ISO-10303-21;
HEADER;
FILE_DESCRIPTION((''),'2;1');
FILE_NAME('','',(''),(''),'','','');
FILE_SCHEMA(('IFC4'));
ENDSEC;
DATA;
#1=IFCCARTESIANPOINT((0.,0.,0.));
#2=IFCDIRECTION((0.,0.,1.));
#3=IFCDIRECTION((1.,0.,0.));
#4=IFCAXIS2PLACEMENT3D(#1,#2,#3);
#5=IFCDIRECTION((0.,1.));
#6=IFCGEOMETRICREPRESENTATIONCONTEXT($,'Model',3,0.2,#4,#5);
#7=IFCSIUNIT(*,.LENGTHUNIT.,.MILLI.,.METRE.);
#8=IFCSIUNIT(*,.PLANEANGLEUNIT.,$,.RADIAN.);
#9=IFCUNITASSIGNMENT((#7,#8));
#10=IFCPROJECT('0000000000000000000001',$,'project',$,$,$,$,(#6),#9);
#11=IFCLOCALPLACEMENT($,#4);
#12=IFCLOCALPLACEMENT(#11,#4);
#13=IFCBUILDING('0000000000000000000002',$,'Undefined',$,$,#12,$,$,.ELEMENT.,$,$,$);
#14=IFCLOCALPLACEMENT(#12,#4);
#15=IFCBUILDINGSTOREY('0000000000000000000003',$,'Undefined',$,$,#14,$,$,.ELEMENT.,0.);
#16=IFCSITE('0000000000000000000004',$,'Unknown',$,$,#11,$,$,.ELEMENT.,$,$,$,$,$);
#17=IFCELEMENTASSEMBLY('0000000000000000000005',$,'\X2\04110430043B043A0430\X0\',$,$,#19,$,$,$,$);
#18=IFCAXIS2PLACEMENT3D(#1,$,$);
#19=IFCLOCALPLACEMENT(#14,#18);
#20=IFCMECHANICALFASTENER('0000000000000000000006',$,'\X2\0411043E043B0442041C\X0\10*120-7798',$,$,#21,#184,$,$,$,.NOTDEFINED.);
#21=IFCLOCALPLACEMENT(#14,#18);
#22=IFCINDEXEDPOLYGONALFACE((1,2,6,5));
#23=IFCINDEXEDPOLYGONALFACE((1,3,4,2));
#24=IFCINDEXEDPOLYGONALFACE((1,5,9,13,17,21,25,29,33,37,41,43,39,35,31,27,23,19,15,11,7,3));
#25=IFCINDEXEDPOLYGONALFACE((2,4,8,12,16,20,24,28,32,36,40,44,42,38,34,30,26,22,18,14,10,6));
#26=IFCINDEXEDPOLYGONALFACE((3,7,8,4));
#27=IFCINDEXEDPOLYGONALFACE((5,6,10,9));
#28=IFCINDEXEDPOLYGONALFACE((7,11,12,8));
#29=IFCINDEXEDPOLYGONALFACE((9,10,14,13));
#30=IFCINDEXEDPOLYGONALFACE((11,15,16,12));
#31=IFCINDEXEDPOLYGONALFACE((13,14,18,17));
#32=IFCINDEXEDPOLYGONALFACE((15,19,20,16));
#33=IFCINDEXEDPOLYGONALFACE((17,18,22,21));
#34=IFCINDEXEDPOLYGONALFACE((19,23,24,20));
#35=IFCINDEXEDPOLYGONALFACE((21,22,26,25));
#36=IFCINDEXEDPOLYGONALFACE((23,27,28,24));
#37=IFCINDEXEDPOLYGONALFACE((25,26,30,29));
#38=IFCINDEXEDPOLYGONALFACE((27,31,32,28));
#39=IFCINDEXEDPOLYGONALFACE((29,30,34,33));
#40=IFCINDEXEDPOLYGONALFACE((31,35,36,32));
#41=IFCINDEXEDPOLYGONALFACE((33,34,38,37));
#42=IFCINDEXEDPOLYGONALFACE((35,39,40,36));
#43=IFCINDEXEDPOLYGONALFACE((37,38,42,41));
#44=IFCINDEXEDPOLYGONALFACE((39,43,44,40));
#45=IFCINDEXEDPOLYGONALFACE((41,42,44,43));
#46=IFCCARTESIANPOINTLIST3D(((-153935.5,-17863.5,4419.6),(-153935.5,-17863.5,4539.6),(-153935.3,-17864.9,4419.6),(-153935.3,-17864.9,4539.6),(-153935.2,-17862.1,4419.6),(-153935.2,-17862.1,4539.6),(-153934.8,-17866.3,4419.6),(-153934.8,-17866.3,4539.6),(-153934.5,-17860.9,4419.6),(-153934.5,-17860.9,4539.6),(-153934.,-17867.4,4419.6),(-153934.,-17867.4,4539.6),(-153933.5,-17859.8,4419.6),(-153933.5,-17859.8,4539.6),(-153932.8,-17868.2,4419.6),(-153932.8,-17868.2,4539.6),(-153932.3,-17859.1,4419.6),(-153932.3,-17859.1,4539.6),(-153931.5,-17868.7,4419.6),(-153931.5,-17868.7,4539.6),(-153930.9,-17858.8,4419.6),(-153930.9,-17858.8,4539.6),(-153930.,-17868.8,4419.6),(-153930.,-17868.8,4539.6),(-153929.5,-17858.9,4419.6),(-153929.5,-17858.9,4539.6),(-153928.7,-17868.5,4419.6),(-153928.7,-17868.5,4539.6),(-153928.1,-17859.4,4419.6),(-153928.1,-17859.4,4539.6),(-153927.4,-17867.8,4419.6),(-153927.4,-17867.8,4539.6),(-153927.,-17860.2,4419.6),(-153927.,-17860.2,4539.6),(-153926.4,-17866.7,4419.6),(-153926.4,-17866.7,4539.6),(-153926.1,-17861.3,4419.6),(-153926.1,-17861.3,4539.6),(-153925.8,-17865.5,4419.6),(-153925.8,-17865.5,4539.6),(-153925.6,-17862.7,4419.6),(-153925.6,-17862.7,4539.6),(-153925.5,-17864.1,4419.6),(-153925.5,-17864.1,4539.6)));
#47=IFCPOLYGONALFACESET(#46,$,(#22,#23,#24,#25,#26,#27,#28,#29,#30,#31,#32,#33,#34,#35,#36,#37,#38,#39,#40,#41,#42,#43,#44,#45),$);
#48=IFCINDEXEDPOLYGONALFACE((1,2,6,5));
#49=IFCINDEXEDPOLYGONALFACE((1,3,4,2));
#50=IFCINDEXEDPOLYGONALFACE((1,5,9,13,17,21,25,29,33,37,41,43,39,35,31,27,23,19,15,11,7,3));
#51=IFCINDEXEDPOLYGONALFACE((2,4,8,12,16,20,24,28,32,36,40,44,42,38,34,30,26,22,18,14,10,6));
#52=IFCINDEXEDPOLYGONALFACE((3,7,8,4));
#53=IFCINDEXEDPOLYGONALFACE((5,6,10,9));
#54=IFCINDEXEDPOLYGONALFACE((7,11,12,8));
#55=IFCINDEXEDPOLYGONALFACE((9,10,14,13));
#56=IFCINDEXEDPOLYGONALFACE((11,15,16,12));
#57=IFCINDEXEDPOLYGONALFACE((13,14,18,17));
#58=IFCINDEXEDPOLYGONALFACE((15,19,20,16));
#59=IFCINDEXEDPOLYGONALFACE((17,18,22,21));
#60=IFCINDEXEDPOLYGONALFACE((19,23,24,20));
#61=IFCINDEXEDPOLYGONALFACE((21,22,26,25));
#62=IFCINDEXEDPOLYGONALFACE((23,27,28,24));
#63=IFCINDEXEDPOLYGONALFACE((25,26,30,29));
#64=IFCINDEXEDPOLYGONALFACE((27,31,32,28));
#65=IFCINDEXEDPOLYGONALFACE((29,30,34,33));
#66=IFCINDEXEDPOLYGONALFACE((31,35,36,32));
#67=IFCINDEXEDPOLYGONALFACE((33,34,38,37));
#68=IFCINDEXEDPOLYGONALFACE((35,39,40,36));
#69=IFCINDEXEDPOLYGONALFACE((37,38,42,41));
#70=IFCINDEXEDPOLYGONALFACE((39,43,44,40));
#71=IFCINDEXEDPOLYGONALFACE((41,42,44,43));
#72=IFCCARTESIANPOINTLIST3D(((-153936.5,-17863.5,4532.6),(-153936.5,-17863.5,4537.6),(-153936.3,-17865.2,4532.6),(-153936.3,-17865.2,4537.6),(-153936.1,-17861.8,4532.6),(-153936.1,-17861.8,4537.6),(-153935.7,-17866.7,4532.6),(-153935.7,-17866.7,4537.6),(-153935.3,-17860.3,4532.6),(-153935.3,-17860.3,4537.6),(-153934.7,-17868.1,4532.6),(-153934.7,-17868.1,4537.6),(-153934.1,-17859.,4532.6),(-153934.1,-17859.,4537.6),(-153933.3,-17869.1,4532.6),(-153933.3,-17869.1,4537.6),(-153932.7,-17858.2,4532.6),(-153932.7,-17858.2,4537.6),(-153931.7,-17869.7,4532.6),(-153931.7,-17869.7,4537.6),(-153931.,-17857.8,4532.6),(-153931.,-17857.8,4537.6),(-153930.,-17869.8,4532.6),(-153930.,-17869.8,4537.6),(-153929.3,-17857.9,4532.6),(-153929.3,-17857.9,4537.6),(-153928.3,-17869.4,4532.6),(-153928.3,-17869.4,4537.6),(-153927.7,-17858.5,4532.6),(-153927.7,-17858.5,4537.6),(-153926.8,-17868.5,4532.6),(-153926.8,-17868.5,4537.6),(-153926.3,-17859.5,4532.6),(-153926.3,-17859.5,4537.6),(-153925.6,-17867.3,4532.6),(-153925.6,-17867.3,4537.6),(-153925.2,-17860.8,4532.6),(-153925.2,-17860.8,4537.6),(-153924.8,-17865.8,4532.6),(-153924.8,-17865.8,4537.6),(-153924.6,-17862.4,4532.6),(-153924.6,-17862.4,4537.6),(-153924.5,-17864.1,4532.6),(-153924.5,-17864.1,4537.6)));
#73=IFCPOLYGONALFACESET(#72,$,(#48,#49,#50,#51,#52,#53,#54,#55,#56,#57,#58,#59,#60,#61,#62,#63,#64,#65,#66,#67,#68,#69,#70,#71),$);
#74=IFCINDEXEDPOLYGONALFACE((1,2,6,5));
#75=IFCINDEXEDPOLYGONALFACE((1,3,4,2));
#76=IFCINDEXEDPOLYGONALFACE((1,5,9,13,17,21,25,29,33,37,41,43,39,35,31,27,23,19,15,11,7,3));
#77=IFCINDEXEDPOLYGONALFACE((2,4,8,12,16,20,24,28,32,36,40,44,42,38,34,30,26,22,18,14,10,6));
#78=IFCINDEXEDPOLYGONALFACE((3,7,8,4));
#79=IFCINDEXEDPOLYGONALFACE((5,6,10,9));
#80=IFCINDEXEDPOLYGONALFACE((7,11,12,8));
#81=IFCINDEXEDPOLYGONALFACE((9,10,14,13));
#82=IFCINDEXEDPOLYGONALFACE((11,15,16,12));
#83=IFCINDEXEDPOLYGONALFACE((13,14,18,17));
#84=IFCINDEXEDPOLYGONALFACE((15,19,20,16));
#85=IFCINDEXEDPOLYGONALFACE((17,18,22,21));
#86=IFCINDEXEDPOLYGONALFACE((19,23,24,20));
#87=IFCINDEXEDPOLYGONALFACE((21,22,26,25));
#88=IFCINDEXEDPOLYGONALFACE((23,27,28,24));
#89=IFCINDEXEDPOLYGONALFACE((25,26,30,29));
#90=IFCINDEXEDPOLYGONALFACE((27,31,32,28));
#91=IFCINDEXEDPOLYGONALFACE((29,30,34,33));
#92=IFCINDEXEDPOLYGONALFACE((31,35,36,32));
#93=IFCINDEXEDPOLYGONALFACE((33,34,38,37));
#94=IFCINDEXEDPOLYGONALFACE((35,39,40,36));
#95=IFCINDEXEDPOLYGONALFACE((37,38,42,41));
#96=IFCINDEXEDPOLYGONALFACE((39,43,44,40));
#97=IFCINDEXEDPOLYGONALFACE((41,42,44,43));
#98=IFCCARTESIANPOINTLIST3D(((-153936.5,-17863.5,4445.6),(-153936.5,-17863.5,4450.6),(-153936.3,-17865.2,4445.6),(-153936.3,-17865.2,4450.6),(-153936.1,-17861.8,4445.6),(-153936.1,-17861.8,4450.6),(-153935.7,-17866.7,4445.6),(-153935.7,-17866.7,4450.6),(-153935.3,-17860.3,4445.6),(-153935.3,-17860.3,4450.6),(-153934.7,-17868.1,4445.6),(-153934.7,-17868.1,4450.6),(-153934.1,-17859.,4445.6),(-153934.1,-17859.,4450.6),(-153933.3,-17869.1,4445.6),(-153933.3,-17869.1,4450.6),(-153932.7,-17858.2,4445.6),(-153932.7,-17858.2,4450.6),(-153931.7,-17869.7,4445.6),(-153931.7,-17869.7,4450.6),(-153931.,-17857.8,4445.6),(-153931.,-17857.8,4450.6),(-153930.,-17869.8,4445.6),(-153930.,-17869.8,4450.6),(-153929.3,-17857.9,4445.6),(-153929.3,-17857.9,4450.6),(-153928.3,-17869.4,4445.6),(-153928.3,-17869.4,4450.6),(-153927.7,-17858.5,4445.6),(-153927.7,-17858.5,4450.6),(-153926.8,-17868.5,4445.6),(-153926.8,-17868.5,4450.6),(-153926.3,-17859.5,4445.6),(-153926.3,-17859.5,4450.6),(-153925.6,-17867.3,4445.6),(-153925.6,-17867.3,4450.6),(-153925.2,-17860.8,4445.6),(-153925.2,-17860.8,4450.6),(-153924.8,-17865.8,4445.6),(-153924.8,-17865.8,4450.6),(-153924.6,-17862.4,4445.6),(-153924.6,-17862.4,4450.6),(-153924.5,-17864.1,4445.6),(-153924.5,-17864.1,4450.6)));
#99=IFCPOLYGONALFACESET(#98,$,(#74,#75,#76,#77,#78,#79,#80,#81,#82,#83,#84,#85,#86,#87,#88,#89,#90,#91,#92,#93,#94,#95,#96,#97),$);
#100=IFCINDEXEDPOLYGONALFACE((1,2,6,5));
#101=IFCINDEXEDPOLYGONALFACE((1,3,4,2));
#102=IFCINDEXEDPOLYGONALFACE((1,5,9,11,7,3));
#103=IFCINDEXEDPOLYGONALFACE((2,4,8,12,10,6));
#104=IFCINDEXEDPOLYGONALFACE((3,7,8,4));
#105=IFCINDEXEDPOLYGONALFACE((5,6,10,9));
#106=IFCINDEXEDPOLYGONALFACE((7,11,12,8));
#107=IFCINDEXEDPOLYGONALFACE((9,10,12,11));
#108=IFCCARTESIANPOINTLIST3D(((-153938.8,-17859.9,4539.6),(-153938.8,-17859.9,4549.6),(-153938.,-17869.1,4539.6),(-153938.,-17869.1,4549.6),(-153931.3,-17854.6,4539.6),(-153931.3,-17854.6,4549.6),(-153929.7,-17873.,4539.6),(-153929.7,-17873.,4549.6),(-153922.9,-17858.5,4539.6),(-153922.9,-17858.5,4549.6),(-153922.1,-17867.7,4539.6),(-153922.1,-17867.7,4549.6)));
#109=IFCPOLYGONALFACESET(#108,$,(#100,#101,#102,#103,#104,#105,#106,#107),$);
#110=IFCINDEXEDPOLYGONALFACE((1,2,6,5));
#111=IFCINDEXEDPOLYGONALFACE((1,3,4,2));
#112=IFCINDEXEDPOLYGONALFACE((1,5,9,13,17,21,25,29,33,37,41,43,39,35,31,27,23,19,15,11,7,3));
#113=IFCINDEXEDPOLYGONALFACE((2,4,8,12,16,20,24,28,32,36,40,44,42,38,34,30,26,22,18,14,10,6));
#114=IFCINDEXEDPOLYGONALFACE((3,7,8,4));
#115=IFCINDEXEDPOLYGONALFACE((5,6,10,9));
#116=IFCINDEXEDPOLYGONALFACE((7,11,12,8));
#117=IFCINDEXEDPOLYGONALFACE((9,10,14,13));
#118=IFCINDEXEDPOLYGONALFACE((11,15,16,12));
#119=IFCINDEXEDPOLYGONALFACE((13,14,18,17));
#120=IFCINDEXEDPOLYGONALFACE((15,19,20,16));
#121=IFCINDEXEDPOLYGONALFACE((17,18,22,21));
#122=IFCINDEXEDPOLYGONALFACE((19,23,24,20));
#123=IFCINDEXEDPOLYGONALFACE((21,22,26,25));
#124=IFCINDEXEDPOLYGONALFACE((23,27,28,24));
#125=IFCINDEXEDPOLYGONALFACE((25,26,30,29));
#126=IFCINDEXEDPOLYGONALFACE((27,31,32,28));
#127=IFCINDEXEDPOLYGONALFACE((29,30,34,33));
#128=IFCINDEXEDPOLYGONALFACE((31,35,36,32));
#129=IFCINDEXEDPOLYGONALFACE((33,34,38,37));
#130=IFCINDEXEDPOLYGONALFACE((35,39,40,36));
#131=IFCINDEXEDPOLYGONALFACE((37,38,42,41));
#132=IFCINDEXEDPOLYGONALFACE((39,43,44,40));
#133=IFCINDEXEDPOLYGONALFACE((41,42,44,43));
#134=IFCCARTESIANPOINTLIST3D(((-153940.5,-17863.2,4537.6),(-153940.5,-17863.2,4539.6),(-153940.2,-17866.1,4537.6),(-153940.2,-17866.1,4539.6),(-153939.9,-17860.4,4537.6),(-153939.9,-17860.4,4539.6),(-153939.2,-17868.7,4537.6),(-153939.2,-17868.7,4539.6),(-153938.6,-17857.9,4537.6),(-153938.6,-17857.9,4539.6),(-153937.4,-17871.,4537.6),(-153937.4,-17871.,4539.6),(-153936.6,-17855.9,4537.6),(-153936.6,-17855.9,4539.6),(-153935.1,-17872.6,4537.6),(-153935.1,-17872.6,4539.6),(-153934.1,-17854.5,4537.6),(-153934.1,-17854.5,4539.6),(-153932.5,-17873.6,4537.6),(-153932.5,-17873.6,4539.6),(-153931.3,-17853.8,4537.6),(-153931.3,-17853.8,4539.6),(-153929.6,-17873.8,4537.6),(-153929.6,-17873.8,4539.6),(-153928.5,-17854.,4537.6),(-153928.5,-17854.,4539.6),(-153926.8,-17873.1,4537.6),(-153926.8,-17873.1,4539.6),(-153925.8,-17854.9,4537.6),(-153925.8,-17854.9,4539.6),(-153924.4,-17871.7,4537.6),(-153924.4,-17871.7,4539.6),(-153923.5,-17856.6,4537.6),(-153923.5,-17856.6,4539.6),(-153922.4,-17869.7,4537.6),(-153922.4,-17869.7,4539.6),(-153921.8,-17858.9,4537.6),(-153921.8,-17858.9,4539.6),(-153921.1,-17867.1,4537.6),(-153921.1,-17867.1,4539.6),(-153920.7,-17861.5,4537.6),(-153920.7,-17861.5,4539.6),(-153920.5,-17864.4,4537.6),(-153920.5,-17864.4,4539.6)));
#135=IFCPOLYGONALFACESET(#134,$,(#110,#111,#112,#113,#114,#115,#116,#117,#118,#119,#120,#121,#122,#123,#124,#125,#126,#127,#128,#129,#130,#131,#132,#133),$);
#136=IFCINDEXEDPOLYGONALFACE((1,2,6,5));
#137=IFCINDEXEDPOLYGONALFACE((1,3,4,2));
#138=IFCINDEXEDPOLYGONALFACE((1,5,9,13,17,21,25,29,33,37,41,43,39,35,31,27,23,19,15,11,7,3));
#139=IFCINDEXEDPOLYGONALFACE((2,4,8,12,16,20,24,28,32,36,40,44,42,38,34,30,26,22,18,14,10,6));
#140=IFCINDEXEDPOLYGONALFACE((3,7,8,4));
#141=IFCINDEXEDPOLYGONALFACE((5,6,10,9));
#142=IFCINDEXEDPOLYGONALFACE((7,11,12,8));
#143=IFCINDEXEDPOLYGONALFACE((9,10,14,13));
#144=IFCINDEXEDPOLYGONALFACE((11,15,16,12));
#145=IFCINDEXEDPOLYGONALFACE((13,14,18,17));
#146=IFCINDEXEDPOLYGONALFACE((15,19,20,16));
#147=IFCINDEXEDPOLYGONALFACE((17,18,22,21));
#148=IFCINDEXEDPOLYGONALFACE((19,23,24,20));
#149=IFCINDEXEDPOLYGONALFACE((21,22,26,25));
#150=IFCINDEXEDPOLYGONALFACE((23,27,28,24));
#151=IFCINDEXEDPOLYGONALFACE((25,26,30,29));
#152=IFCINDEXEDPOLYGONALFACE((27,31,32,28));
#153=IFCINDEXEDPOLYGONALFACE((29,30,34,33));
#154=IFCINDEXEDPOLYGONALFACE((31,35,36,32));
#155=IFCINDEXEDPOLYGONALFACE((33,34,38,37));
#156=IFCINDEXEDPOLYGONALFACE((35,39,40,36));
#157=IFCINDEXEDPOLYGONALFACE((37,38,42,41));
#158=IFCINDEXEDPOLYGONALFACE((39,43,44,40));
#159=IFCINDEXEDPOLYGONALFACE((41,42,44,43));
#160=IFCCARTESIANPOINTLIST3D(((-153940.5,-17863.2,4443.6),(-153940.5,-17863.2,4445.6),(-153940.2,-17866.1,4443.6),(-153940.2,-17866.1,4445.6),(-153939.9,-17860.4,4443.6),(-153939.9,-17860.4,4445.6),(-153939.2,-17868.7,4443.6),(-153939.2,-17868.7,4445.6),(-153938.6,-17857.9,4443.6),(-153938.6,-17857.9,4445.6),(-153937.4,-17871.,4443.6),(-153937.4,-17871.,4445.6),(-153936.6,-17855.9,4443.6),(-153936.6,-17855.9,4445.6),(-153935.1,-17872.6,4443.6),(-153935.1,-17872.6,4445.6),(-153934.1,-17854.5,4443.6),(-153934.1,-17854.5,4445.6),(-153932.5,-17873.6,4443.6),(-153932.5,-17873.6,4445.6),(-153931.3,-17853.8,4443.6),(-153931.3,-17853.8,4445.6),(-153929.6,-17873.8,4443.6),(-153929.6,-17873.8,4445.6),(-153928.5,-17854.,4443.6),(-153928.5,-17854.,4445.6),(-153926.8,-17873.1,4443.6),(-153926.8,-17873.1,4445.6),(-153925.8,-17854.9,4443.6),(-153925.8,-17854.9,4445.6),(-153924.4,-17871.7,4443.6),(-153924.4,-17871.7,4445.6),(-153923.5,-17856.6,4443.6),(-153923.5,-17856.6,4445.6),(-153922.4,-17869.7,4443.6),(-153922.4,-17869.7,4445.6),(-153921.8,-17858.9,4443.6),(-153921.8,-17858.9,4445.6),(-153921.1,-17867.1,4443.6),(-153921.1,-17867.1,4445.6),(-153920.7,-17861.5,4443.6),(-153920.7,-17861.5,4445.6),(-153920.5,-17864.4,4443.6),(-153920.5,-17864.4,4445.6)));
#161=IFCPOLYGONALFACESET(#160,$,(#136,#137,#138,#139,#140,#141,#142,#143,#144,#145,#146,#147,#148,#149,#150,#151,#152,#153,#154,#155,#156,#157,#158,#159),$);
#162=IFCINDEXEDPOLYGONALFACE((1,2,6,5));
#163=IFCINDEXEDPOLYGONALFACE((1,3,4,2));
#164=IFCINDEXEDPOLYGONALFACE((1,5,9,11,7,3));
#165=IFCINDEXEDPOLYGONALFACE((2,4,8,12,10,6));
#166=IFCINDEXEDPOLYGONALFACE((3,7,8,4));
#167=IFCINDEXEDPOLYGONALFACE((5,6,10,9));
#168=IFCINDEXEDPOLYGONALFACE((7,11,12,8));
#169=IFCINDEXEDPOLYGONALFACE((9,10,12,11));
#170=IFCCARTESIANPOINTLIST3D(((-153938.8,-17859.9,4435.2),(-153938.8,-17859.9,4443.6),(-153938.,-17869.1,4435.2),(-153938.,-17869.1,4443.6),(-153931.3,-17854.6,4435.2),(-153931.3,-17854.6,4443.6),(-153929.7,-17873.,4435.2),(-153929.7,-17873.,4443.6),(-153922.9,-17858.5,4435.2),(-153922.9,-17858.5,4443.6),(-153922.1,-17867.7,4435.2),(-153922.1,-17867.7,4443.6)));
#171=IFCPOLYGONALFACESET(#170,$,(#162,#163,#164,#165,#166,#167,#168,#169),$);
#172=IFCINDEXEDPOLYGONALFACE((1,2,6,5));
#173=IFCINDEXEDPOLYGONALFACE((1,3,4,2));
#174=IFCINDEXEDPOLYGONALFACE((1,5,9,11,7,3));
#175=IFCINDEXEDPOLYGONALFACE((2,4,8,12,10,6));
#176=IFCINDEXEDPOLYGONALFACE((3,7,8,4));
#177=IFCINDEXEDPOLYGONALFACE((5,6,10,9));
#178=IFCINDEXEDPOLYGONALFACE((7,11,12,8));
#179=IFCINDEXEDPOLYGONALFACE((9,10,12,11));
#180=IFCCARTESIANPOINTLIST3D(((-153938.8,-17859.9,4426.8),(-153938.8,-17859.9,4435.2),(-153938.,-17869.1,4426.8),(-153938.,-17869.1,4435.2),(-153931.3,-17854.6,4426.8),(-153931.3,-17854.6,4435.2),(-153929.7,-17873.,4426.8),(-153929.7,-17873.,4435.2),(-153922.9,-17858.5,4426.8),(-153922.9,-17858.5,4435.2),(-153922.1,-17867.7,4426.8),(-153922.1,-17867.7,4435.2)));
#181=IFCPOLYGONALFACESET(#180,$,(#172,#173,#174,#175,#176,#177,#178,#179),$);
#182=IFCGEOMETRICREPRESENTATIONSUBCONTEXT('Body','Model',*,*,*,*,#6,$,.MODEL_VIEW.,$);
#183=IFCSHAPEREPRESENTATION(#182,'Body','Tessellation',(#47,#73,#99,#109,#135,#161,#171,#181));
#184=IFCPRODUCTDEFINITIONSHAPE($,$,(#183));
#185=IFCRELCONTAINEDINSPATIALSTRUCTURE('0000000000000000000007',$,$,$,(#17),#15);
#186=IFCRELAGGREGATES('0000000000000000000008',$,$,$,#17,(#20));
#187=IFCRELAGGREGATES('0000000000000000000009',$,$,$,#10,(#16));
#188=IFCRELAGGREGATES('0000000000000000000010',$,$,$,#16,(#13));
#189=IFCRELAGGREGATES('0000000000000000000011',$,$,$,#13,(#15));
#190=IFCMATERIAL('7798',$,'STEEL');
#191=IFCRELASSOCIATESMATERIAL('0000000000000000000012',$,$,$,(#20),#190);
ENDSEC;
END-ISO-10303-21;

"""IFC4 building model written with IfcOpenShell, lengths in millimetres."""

from ifc_helpers import new_model, si_unit, direction, frame, origin_with_axes, place, context, subcontext, project, spatial, line, arc, indexed_curve, outline, extrude, source, transform, mapped, material, element, aggregate, save


model = new_model("IFC4")

# Units and contexts
model_context = context("Model", 3, precision=0.2, world=origin_with_axes(), true_north=direction((0.0, 1.0)))
body_context = subcontext(model_context, "Body", "Model", "MODEL_VIEW")
ifc_project = project(units=[si_unit("LENGTHUNIT", "METRE", prefix="MILLI"), si_unit("PLANEANGLEUNIT", "RADIAN")], contexts=[model_context])

# Site, building, storey
site_placement = place(None, origin_with_axes())
site = spatial("IfcSite", under=ifc_project, at=site_placement, Name="Unknown", CompositionType="ELEMENT")
building_placement = place(site_placement, origin_with_axes())
building = spatial("IfcBuilding", under=site, at=building_placement, Name="Undefined", CompositionType="ELEMENT")
storey_placement = place(building_placement, origin_with_axes())
storey = spatial("IfcBuildingStorey", under=building, at=storey_placement, Name="Undefined", CompositionType="ELEMENT", Elevation=0.0)

# Element assembly
assembly_1_placement = place(storey_placement, frame((-154078.4, -17876.6, 4581.6), z_axis=(0.996285, 0.086114, 0.0), x_axis=(0.0, 0.0, -1.0)))
assembly_1 = element("IfcElementAssembly", 1, at=assembly_1_placement, inside=storey, Name="Балка")

# Shared definitions
ifc_material_1 = material(Name="7798", Category="STEEL")

# Mechanical fastener
shared_shape_1 = source(origin_with_axes(), body_context, "Body", "SweptSolid", [
    extrude(outline(indexed_curve([(5.0, 0.0), (0.0, 5.0), (-5.0, 0.0), (0.0, -5.0)], segments=[arc(1, 2, 3), arc(3, 4, 1)])), frame((0.0, 0.0, 7.0), z_axis=(0.0, 0.0, -1.0), x_axis=(0.0, 1.0, 0.0)), (0.0, 0.0, 1.0), 120.0),
    extrude(outline(indexed_curve([(6.0, 0.0), (0.0, 6.0), (-6.0, 0.0), (0.0, -6.0)], segments=[arc(1, 2, 3), arc(3, 4, 1)])), frame((0.0, 0.0, 5.0), z_axis=(0.0, 0.0, -1.0), x_axis=(0.0, 1.0, 0.0)), (0.0, 0.0, 1.0), 5.0),
    extrude(outline(indexed_curve([(6.0, 0.0), (0.0, 6.0), (-6.0, 0.0), (0.0, -6.0)], segments=[arc(1, 2, 3), arc(3, 4, 1)])), frame((0.0, 0.0, -82.0), z_axis=(0.0, 0.0, -1.0), x_axis=(0.0, 1.0, 0.0)), (0.0, 0.0, 1.0), 5.0),
    extrude(outline(indexed_curve([(9.2, 0.0), (4.6, 8.0), (-4.6, 8.0), (-9.2, 0.0), (-4.6, -8.0), (4.6, -8.0)], segments=[line(1, 2, 3, 4, 5, 6, 1)])), frame((0.0, 0.0, 17.0), z_axis=(0.0, 0.0, -1.0), x_axis=(0.0, 1.0, 0.0)), (0.0, 0.0, 1.0), 10.0),
    extrude(outline(indexed_curve([(10.0, 0.0), (0.0, 10.0), (-10.0, 0.0), (0.0, -10.0)], segments=[arc(1, 2, 3), arc(3, 4, 1)])), frame((0.0, 0.0, 7.0), z_axis=(0.0, 0.0, -1.0), x_axis=(0.0, 1.0, 0.0)), (0.0, 0.0, 1.0), 2.0),
    extrude(outline(indexed_curve([(10.0, 0.0), (0.0, 10.0), (-10.0, 0.0), (0.0, -10.0)], segments=[arc(1, 2, 3), arc(3, 4, 1)])), frame((0.0, 0.0, -87.0), z_axis=(0.0, 0.0, -1.0), x_axis=(0.0, 1.0, 0.0)), (0.0, 0.0, 1.0), 2.0),
    extrude(outline(indexed_curve([(9.2, 0.0), (4.6, 8.0), (-4.6, 8.0), (-9.2, 0.0), (-4.6, -8.0), (4.6, -8.0)], segments=[line(1, 2, 3, 4, 5, 6, 1)])), frame((0.0, 0.0, -89.0), z_axis=(0.0, 0.0, -1.0), x_axis=(0.0, 1.0, 0.0)), (0.0, 0.0, 1.0), 8.4),
    extrude(outline(indexed_curve([(9.2, 0.0), (4.6, 8.0), (-4.6, 8.0), (-9.2, 0.0), (-4.6, -8.0), (4.6, -8.0)], segments=[line(1, 2, 3, 4, 5, 6, 1)])), frame((0.0, 0.0, -97.4), z_axis=(0.0, 0.0, -1.0), x_axis=(0.0, 1.0, 0.0)), (0.0, 0.0, 1.0), 8.4),
])
mechanical_fastener_1_placement = place(assembly_1_placement, frame((49.0, 0.0, 148.5), z_axis=(-1.0, 0.0, 0.0), x_axis=(0.0, 0.0, -1.0)))
mechanical_fastener_1 = element("IfcMechanicalFastener", 2, at=mechanical_fastener_1_placement, material=ifc_material_1, Name="БолтМ10*120-7798", PredefinedType="NOTDEFINED", context=body_context, shape_type="MappedRepresentation", body=[
    mapped(shared_shape_1, transform((0.0, 0.0, 0.0))),
])
aggregate(assembly_1, [mechanical_fastener_1])

save(model, "model.ifc")
